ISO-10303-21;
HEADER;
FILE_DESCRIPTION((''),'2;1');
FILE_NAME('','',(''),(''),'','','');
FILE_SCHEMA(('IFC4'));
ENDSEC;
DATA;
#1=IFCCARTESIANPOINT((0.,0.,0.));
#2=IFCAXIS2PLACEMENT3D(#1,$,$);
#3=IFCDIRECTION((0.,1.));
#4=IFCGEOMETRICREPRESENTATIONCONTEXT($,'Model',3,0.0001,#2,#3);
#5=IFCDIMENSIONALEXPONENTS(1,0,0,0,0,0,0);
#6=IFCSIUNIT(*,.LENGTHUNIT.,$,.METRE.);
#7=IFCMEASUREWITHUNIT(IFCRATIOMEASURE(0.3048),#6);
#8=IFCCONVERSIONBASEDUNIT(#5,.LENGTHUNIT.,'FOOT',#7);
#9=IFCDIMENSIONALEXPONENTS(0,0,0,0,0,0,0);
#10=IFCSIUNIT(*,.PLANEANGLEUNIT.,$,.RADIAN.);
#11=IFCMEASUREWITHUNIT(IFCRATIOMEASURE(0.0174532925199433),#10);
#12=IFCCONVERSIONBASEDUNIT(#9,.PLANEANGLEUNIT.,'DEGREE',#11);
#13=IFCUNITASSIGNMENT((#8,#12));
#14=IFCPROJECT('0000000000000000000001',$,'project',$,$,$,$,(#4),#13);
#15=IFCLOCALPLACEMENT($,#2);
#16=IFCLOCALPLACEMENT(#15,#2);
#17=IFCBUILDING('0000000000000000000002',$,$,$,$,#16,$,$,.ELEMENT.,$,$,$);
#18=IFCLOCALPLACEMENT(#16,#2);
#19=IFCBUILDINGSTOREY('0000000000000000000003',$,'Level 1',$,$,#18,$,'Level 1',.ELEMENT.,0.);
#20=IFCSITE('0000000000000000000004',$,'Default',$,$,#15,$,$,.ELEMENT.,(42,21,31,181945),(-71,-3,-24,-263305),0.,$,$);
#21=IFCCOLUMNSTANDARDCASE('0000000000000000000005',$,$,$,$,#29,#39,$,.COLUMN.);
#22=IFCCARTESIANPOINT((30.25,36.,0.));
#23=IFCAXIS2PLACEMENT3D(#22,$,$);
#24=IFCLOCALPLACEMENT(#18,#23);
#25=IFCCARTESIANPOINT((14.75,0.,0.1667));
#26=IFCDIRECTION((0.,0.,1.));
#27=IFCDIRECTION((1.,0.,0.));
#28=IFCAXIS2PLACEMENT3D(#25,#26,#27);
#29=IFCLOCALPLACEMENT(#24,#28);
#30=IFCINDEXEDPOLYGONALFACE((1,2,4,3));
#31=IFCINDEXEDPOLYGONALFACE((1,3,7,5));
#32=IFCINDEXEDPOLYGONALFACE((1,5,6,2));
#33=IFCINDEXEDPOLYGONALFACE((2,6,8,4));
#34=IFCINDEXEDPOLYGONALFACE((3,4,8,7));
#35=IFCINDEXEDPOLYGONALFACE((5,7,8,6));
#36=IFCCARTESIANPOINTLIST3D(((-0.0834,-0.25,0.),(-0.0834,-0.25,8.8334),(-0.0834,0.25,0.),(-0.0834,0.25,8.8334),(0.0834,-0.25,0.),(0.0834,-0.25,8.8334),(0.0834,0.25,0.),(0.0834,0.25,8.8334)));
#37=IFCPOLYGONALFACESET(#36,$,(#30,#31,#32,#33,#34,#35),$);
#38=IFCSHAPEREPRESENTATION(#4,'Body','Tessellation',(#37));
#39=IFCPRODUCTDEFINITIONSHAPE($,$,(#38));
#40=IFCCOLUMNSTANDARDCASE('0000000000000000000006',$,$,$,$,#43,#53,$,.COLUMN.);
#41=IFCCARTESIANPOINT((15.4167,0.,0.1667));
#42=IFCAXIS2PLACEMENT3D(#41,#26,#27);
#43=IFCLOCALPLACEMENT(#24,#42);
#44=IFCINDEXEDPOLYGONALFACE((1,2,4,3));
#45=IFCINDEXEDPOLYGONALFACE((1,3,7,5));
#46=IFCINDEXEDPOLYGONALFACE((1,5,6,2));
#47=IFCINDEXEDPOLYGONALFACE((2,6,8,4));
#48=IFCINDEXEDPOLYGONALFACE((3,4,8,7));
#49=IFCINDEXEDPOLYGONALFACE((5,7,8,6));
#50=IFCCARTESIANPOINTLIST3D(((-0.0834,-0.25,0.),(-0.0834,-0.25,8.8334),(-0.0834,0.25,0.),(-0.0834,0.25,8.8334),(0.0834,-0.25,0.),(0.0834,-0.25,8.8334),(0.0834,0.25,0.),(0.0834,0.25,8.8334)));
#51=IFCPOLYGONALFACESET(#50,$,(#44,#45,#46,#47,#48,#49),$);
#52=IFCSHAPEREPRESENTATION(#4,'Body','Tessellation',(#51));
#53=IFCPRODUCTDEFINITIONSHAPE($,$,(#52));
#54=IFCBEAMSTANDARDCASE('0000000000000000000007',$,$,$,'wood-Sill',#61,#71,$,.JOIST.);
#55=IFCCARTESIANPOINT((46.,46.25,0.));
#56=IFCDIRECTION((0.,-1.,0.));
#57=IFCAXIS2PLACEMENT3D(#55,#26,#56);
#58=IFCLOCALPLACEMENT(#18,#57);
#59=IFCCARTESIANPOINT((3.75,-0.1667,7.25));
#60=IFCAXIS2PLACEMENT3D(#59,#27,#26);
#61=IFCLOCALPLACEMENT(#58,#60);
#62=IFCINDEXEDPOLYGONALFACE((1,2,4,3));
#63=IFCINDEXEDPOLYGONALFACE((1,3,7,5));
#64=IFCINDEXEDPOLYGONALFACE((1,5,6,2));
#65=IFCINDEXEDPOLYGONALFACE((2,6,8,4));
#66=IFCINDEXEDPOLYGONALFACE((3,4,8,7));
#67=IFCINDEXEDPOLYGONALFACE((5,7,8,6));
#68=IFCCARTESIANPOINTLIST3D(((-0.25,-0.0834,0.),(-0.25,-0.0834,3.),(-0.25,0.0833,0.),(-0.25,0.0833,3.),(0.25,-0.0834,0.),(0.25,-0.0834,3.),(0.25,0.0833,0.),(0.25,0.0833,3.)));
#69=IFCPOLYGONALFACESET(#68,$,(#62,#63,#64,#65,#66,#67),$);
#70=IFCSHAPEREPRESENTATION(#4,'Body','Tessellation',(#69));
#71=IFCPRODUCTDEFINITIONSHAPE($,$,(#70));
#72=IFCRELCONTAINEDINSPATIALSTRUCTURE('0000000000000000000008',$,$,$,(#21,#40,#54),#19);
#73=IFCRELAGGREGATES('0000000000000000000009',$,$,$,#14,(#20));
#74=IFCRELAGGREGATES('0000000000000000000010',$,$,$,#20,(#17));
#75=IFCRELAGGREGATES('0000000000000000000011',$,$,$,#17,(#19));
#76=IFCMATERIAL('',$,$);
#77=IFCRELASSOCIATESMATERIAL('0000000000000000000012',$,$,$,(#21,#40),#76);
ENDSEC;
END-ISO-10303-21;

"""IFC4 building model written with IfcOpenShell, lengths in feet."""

from ifc_helpers import new_model, entity, si_unit, converted_unit, direction, frame, origin, origin_with_axes, place, context, project, spatial, rectangle, extrude, material, element, save


model = new_model("IFC4")

# Units and contexts
model_context = context("Model", 3, precision=0.0001, world=origin(), true_north=direction((0.0, 1.0)))
ifc_project = project(units=[converted_unit("LENGTHUNIT", "FOOT", entity("IfcRatioMeasure", 0.3048), si_unit("LENGTHUNIT", "METRE"), dimensions=[1, 0, 0, 0, 0, 0, 0]), converted_unit("PLANEANGLEUNIT", "DEGREE", entity("IfcRatioMeasure", 0.0174532925199433), si_unit("PLANEANGLEUNIT", "RADIAN"), dimensions=[0, 0, 0, 0, 0, 0, 0])], contexts=[model_context])

# Site, building, storey
site_placement = place(None, origin())
site = spatial("IfcSite", under=ifc_project, at=site_placement, Name="Default", CompositionType="ELEMENT", RefLatitude=(42, 21, 31, 181945), RefLongitude=(-71, -3, -24, -263305), RefElevation=0.0)
building_placement = place(site_placement, origin())
building = spatial("IfcBuilding", under=site, at=building_placement, CompositionType="ELEMENT")
storey_placement = place(building_placement, origin())
storey = spatial("IfcBuildingStorey", under=building, at=storey_placement, Name="Level 1", LongName="Level 1", CompositionType="ELEMENT", Elevation=0.0)

# Columns
ifc_material_1 = material(Name="")
placement_1 = place(storey_placement, frame((46.0, 46.25, 0.0), z_axis=(0.0, 0.0, 1.0), x_axis=(0.0, -1.0, 0.0)))
placement_2 = place(storey_placement, frame((30.25, 36.0, 0.0)))
for number, where, z_axis, x_axis in (
    (1, (14.75, 0.0, 0.1667), (0.0, 0.0, 1.0), (1.0, 0.0, 0.0)),
    (2, (15.4167, 0.0, 0.1667), (0.0, 0.0, 1.0), (1.0, 0.0, 0.0)),
):
    element("IfcColumnStandardCase", number, at=place(placement_2, frame(where, z_axis=z_axis, x_axis=x_axis)), inside=storey, material=ifc_material_1, PredefinedType="COLUMN", context=model_context, shape_type="SweptSolid", body=[
        extrude(rectangle(XDim=0.1667, YDim=0.5), origin(), (0.0, 0.0, 1.0), 8.8334),
    ])

# Beam
for number, where, z_axis, x_axis in (
    (3, (3.75, -0.1667, 7.25), (1.0, 0.0, 0.0), (0.0, 0.0, 1.0)),
):
    element("IfcBeamStandardCase", number, at=place(placement_1, frame(where, z_axis=z_axis, x_axis=x_axis)), inside=storey, ObjectType="wood-Sill", PredefinedType="JOIST", context=model_context, shape_type="SweptSolid", body=[
        extrude(rectangle(XDim=0.5, YDim=0.1667), origin_with_axes(), (0.0, 0.0, 1.0), 3.0),
    ])

save(model, "model.ifc")
